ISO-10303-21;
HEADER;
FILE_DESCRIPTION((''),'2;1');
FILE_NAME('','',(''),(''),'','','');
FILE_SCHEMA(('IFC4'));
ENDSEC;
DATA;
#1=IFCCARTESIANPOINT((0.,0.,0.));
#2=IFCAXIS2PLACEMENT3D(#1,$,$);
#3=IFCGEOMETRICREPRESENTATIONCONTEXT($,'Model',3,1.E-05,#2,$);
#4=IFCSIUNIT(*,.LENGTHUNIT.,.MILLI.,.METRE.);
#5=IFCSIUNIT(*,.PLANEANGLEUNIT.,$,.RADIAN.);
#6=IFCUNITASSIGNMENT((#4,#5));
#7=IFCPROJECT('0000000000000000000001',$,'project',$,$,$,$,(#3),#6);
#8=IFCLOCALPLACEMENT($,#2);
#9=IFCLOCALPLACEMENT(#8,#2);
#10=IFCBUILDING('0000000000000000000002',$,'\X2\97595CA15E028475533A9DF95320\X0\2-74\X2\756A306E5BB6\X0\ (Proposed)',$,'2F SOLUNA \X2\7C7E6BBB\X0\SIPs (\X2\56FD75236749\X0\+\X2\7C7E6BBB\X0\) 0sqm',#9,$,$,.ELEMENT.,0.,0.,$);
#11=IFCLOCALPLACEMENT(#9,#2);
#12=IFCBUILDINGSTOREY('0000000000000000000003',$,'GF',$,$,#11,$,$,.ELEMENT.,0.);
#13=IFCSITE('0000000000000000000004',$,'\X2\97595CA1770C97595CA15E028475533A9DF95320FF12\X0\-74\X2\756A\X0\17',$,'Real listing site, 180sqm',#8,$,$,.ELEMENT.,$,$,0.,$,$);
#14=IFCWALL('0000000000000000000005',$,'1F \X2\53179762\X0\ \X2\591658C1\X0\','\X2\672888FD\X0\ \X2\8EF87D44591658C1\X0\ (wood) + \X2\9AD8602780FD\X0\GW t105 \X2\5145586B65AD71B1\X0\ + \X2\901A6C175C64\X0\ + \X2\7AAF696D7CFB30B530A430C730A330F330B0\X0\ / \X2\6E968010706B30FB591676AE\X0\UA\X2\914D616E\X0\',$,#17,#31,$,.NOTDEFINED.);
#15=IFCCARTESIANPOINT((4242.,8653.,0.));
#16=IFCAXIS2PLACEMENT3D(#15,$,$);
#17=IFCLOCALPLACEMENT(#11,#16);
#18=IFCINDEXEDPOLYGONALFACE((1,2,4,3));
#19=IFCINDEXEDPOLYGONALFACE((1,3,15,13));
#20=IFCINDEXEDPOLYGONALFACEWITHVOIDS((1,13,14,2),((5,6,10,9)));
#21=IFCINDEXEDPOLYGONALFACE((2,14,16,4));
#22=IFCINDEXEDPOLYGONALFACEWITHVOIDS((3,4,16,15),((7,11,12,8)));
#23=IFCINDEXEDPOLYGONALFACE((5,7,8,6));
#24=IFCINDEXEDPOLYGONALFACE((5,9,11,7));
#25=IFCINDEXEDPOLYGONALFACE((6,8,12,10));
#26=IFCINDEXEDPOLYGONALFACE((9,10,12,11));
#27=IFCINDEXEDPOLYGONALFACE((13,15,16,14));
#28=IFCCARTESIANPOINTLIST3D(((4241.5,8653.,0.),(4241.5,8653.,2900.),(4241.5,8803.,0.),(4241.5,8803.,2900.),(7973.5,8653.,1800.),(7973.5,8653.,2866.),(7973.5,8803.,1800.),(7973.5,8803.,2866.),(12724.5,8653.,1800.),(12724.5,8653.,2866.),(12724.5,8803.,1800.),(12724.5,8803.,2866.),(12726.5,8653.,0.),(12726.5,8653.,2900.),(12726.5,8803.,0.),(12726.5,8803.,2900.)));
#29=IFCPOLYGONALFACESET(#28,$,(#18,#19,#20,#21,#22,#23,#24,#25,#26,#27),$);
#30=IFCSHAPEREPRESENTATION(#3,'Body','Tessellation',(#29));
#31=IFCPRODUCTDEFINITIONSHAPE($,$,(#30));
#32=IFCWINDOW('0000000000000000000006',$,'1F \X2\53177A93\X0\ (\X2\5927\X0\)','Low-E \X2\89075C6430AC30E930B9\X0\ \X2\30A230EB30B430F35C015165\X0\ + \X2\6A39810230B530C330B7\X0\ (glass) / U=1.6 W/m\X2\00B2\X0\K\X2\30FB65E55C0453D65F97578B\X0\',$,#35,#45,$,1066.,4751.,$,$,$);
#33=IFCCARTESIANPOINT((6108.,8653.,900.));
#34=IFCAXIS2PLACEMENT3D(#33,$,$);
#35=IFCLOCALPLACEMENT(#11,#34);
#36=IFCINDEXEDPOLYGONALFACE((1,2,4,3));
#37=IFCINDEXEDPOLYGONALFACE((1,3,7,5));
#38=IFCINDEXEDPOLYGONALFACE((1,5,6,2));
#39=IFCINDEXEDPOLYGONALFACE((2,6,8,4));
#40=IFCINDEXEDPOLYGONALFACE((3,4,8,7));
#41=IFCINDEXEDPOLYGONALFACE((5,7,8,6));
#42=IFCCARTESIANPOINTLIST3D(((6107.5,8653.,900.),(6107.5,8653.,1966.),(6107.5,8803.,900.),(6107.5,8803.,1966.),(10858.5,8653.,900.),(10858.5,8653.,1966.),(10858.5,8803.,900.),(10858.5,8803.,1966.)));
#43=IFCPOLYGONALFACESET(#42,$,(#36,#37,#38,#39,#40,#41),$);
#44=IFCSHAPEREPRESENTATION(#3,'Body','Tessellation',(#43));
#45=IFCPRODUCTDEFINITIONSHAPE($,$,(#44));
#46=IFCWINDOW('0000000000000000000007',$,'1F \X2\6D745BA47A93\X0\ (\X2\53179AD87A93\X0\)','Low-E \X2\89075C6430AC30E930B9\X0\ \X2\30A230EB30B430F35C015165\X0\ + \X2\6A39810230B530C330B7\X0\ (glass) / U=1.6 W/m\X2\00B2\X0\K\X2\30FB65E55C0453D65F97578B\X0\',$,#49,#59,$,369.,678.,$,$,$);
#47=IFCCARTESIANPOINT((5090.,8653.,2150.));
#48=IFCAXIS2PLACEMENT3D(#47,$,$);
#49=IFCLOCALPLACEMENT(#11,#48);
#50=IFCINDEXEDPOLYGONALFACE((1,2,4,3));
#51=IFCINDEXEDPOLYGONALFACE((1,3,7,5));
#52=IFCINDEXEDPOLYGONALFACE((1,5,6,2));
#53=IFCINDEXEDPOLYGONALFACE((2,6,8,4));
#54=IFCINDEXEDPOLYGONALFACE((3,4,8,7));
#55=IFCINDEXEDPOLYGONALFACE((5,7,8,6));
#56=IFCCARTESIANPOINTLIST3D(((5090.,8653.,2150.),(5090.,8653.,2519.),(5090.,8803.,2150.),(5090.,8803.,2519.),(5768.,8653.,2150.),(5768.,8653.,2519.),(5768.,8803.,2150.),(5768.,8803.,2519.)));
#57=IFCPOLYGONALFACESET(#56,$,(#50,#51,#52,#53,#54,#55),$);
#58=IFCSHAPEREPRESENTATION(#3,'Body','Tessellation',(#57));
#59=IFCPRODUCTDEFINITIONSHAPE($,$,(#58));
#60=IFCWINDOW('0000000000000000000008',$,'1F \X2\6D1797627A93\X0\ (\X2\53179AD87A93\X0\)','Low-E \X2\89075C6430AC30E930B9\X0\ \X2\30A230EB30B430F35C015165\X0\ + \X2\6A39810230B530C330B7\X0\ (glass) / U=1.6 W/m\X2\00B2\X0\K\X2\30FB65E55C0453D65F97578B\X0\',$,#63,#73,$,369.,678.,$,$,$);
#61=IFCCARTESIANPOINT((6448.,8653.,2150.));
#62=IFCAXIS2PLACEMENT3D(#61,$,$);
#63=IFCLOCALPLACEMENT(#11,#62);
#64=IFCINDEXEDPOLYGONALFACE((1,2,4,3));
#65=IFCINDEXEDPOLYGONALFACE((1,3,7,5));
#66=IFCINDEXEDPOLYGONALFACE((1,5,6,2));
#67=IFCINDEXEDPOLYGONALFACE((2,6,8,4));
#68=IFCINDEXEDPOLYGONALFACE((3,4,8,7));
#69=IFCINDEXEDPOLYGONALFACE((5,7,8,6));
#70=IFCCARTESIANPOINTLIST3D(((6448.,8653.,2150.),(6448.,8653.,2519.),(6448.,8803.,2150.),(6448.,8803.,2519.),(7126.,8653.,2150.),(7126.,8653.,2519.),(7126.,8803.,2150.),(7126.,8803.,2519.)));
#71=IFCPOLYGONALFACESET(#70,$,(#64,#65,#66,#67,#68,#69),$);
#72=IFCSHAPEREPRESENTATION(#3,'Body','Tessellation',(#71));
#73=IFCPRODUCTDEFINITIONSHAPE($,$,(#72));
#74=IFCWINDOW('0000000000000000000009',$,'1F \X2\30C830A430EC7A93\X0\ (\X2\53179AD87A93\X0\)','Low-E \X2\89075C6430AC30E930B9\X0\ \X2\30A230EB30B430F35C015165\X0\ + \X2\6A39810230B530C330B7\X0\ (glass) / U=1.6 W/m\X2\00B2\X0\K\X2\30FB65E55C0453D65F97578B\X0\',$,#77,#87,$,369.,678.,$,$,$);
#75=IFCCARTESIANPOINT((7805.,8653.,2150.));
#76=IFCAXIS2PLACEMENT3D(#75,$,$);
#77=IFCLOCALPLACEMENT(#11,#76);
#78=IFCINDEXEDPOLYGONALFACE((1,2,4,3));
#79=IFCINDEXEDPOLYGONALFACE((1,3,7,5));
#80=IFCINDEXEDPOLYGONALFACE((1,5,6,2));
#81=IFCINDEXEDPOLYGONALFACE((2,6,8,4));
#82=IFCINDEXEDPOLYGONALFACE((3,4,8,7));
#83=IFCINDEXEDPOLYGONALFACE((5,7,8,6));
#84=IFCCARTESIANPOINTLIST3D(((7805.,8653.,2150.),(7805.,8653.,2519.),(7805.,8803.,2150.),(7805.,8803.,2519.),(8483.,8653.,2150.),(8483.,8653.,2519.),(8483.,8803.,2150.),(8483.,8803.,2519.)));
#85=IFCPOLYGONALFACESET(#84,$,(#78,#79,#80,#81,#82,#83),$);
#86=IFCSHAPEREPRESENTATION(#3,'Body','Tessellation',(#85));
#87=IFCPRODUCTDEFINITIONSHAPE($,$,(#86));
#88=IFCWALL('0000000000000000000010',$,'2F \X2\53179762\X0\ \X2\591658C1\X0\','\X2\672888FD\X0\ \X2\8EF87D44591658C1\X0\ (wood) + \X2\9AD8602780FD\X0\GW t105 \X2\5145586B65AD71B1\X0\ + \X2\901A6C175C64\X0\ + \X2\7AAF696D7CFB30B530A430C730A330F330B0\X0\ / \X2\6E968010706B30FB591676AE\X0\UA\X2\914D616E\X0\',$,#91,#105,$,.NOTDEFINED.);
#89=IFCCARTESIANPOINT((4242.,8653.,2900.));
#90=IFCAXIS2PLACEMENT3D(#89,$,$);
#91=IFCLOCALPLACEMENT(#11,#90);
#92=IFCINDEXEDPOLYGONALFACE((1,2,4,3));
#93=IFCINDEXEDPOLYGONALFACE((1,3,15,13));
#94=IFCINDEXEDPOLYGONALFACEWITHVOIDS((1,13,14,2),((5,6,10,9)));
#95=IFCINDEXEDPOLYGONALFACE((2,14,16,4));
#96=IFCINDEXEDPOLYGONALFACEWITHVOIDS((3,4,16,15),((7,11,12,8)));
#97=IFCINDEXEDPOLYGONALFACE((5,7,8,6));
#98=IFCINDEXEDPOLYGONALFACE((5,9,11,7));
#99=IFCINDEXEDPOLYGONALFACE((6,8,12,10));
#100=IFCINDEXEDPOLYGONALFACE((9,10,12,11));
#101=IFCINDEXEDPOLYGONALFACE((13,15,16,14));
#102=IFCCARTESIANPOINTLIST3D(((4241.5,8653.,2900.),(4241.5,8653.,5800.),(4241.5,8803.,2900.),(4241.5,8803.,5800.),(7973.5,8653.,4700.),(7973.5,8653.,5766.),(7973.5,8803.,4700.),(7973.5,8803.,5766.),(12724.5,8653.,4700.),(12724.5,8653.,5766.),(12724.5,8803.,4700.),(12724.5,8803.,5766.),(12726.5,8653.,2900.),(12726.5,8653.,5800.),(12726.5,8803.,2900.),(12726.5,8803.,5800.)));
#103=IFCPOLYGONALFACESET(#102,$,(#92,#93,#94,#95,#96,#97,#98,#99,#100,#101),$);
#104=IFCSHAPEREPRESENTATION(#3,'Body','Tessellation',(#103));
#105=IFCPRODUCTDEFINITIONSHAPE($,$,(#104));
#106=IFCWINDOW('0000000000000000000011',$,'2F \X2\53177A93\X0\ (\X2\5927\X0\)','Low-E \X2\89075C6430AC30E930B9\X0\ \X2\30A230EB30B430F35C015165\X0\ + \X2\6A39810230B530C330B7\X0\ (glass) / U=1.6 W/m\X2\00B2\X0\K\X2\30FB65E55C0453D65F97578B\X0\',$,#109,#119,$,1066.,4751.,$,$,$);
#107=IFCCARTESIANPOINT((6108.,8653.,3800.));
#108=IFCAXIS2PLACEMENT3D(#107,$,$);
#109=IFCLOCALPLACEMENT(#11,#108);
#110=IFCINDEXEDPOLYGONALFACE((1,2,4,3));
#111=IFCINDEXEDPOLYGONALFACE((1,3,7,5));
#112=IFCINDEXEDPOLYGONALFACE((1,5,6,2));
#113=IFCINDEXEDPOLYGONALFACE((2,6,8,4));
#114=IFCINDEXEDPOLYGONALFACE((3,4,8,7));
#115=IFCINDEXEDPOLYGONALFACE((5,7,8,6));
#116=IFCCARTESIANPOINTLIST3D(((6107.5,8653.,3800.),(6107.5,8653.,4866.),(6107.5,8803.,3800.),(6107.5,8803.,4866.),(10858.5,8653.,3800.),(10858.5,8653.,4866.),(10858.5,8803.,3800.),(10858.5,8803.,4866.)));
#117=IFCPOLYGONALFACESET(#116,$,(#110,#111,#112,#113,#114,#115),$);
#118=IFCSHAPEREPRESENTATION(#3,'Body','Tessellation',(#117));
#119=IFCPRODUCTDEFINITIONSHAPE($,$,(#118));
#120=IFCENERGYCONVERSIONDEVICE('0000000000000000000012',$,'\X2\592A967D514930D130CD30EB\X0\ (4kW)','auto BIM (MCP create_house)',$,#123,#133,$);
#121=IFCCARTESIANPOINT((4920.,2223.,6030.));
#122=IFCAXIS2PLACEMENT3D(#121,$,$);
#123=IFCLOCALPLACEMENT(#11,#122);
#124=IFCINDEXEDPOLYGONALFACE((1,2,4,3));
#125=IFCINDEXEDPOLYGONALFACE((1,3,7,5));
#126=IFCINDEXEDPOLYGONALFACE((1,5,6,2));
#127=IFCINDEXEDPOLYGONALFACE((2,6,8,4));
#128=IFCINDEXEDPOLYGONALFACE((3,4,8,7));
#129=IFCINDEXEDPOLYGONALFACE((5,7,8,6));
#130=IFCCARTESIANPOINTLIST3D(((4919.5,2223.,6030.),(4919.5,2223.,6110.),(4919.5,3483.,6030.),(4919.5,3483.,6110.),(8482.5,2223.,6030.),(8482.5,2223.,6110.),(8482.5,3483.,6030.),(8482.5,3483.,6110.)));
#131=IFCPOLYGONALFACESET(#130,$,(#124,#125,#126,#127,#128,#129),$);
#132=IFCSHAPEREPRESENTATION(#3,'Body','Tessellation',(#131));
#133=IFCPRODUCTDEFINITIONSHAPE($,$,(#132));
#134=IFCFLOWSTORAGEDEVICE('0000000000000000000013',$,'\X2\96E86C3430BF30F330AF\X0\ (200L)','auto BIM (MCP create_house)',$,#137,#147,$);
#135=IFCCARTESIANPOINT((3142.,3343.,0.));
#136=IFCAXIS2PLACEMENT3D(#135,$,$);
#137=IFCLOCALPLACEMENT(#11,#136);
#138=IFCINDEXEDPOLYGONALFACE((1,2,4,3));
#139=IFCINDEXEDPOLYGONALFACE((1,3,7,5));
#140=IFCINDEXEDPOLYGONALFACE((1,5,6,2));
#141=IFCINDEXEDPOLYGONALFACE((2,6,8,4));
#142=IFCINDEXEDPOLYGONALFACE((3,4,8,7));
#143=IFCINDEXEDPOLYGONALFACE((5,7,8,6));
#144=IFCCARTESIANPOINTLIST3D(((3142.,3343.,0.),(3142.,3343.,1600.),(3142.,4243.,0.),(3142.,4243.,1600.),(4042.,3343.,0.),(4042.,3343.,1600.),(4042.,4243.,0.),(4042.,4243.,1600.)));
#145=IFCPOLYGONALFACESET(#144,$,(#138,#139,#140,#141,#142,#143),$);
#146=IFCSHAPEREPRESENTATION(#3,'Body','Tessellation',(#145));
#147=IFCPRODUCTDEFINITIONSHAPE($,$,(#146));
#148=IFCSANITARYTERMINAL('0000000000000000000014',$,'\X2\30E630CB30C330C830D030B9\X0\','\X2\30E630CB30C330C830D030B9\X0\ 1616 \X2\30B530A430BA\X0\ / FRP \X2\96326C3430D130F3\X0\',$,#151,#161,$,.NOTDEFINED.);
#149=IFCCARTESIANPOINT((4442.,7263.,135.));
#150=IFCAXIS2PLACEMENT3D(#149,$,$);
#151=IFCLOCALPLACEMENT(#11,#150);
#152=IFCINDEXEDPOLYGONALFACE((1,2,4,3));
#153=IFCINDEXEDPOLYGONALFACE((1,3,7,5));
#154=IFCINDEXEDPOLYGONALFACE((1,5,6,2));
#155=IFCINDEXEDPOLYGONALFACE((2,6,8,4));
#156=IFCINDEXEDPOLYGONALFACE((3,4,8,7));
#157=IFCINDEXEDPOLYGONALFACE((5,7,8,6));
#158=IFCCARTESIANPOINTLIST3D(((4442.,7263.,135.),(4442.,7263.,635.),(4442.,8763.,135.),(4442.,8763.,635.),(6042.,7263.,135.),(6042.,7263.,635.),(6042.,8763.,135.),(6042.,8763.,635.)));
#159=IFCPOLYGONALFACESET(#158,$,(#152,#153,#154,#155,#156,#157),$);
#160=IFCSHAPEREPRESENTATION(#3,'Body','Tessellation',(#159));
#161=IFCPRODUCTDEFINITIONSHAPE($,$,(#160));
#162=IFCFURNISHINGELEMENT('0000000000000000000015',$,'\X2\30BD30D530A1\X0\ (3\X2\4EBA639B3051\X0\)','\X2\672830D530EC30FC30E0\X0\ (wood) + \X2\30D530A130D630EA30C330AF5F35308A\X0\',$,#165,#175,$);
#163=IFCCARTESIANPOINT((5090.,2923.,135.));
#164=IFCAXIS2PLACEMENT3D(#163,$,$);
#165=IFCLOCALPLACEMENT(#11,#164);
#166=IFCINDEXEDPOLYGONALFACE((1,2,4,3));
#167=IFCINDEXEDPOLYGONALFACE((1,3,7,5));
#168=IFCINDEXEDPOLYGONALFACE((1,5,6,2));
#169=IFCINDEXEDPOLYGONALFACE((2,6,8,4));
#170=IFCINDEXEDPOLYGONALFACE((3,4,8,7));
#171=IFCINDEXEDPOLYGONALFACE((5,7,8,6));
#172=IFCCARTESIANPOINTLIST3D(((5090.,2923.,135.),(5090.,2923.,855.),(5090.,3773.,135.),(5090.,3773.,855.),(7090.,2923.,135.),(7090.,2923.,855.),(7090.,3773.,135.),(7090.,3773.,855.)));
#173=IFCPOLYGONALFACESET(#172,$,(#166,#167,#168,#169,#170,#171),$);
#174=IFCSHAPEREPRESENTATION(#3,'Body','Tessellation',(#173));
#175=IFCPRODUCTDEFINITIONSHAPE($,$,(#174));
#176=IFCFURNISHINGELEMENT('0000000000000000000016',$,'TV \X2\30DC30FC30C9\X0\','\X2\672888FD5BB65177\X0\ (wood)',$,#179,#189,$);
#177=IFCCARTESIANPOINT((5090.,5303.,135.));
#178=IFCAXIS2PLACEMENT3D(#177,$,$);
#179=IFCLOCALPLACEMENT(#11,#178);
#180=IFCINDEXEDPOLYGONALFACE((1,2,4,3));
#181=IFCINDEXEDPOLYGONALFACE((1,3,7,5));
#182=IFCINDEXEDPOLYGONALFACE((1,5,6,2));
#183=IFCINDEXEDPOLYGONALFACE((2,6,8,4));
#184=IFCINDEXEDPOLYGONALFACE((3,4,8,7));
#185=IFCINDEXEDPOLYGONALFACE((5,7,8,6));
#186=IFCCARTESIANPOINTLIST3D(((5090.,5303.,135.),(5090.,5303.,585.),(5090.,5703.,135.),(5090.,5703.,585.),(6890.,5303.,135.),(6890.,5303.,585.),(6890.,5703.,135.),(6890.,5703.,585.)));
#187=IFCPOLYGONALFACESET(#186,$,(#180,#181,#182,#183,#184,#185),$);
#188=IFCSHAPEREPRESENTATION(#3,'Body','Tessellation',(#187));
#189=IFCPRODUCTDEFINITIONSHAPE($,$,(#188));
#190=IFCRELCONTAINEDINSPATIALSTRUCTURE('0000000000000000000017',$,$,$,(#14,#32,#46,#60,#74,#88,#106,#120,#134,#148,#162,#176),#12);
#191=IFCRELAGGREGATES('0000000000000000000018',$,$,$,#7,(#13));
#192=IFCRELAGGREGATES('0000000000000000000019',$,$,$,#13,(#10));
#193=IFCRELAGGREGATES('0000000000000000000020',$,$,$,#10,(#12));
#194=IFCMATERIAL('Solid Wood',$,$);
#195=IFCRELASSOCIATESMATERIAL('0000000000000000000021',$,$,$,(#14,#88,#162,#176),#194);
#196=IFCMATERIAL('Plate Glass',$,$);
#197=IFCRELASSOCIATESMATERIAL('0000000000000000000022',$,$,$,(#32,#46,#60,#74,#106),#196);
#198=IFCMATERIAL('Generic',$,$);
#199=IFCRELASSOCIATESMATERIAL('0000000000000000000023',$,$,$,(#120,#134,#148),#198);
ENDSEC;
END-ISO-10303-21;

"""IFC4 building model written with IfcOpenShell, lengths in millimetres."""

from ifc_helpers import new_model, si_unit, frame, frame_2d, origin, place, context, project, spatial, rectangle, extrude, material, element, fill, save


model = new_model("IFC4")

# Units and contexts
model_context = context("Model", 3, precision=1e-05, world=origin())
ifc_project = project(units=[si_unit("LENGTHUNIT", "METRE", prefix="MILLI"), si_unit("PLANEANGLEUNIT", "RADIAN")], contexts=[model_context])

# Site, building, storey
site_placement = place(None, origin())
site = spatial("IfcSite", under=ifc_project, at=site_placement, Name="静岡県静岡市葵区鷹匠２-74番17", ObjectType="Real listing site, 180sqm", CompositionType="ELEMENT", RefElevation=0.0)
building_placement = place(site_placement, origin())
building = spatial("IfcBuilding", under=site, at=building_placement, Name="静岡市葵区鷹匠2-74番の家 (Proposed)", ObjectType="2F SOLUNA 籾殻SIPs (国産杉+籾殻) 0sqm", CompositionType="ELEMENT", ElevationOfRefHeight=0.0, ElevationOfTerrain=0.0)
storey_placement = place(building_placement, origin())
storey = spatial("IfcBuildingStorey", under=building, at=storey_placement, Name="GF", CompositionType="ELEMENT", Elevation=0.0)

# Wall, openings, windows
ifc_material_1 = material(Name="Solid Wood")
wall_1_placement = place(storey_placement, frame((4242.0, 8653.0, 0.0)))
wall_1 = element("IfcWall", 1, at=wall_1_placement, inside=storey, material=ifc_material_1, Name="1F 北面 外壁", Description="木製 軸組外壁 (wood) + 高性能GW t105 充填断熱 + 通気層 + 窯業系サイディング / 準耐火・外皮UA配慮", PredefinedType="NOTDEFINED", context=model_context, shape_type="SweptSolid", body=[
    extrude(rectangle(XDim=8485.0, YDim=150.0, at=frame_2d((4242.0, 75.0))), frame((4242.0, 8653.0, 0.0)), (0.0, 0.0, 1.0), 2900.0),
])
opening_1_placement = place(storey_placement, frame((6108.0, 8653.0, 900.0)))
opening_1 = element("IfcOpeningElement", 2, at=opening_1_placement, cuts=wall_1, PredefinedType="NOTDEFINED", context=model_context, shape_type="SweptSolid", body=[
    extrude(rectangle(XDim=4751.0, YDim=150.0, at=frame_2d((2375.0, 75.0))), frame((6108.0, 8653.0, 900.0)), (0.0, 0.0, 1.0), 1066.0),
])
opening_2_placement = place(storey_placement, frame((5090.0, 8653.0, 2150.0)))
opening_2 = element("IfcOpeningElement", 3, at=opening_2_placement, cuts=wall_1, PredefinedType="NOTDEFINED", context=model_context, shape_type="SweptSolid", body=[
    extrude(rectangle(XDim=678.0, YDim=150.0, at=frame_2d((339.0, 75.0))), frame((5090.0, 8653.0, 2150.0)), (0.0, 0.0, 1.0), 369.0),
])
opening_3_placement = place(storey_placement, frame((6448.0, 8653.0, 2150.0)))
opening_3 = element("IfcOpeningElement", 4, at=opening_3_placement, cuts=wall_1, PredefinedType="NOTDEFINED", context=model_context, shape_type="SweptSolid", body=[
    extrude(rectangle(XDim=678.0, YDim=150.0, at=frame_2d((339.0, 75.0))), frame((6448.0, 8653.0, 2150.0)), (0.0, 0.0, 1.0), 369.0),
])
opening_4_placement = place(storey_placement, frame((7805.0, 8653.0, 2150.0)))
opening_4 = element("IfcOpeningElement", 5, at=opening_4_placement, cuts=wall_1, PredefinedType="NOTDEFINED", context=model_context, shape_type="SweptSolid", body=[
    extrude(rectangle(XDim=678.0, YDim=150.0, at=frame_2d((339.0, 75.0))), frame((7805.0, 8653.0, 2150.0)), (0.0, 0.0, 1.0), 369.0),
])
ifc_material_2 = material(Name="Plate Glass")
window_1_placement = place(storey_placement, frame((6108.0, 8653.0, 900.0)))
window_1 = element("IfcWindow", 6, at=window_1_placement, inside=storey, material=ifc_material_2, Name="1F 北窓 (大)", Description="Low-E 複層ガラス アルゴン封入 + 樹脂サッシ (glass) / U=1.6 W/m²K・日射取得型", OverallHeight=1066.0, OverallWidth=4751.0, context=model_context, shape_type="SweptSolid", body=[
    extrude(rectangle(XDim=4751.0, YDim=150.0, at=frame_2d((2375.0, 75.0))), frame((6108.0, 8653.0, 900.0)), (0.0, 0.0, 1.0), 1066.0),
])
fill(opening_1, window_1)
window_2_placement = place(storey_placement, frame((5090.0, 8653.0, 2150.0)))
window_2 = element("IfcWindow", 7, at=window_2_placement, inside=storey, material=ifc_material_2, Name="1F 浴室窓 (北高窓)", Description="Low-E 複層ガラス アルゴン封入 + 樹脂サッシ (glass) / U=1.6 W/m²K・日射取得型", OverallHeight=369.0, OverallWidth=678.0, context=model_context, shape_type="SweptSolid", body=[
    extrude(rectangle(XDim=678.0, YDim=150.0, at=frame_2d((339.0, 75.0))), frame((5090.0, 8653.0, 2150.0)), (0.0, 0.0, 1.0), 369.0),
])
fill(opening_2, window_2)
window_3_placement = place(storey_placement, frame((6448.0, 8653.0, 2150.0)))
window_3 = element("IfcWindow", 8, at=window_3_placement, inside=storey, material=ifc_material_2, Name="1F 洗面窓 (北高窓)", Description="Low-E 複層ガラス アルゴン封入 + 樹脂サッシ (glass) / U=1.6 W/m²K・日射取得型", OverallHeight=369.0, OverallWidth=678.0, context=model_context, shape_type="SweptSolid", body=[
    extrude(rectangle(XDim=678.0, YDim=150.0, at=frame_2d((339.0, 75.0))), frame((6448.0, 8653.0, 2150.0)), (0.0, 0.0, 1.0), 369.0),
])
fill(opening_3, window_3)
window_4_placement = place(storey_placement, frame((7805.0, 8653.0, 2150.0)))
window_4 = element("IfcWindow", 9, at=window_4_placement, inside=storey, material=ifc_material_2, Name="1F トイレ窓 (北高窓)", Description="Low-E 複層ガラス アルゴン封入 + 樹脂サッシ (glass) / U=1.6 W/m²K・日射取得型", OverallHeight=369.0, OverallWidth=678.0, context=model_context, shape_type="SweptSolid", body=[
    extrude(rectangle(XDim=678.0, YDim=150.0, at=frame_2d((339.0, 75.0))), frame((7805.0, 8653.0, 2150.0)), (0.0, 0.0, 1.0), 369.0),
])
fill(opening_4, window_4)

# Wall, opening, window
wall_2_placement = place(storey_placement, frame((4242.0, 8653.0, 2900.0)))
wall_2 = element("IfcWall", 10, at=wall_2_placement, inside=storey, material=ifc_material_1, Name="2F 北面 外壁", Description="木製 軸組外壁 (wood) + 高性能GW t105 充填断熱 + 通気層 + 窯業系サイディング / 準耐火・外皮UA配慮", PredefinedType="NOTDEFINED", context=model_context, shape_type="SweptSolid", body=[
    extrude(rectangle(XDim=8485.0, YDim=150.0, at=frame_2d((4242.0, 75.0))), frame((4242.0, 8653.0, 2900.0)), (0.0, 0.0, 1.0), 2900.0),
])
opening_5_placement = place(storey_placement, frame((6108.0, 8653.0, 3800.0)))
opening_5 = element("IfcOpeningElement", 11, at=opening_5_placement, cuts=wall_2, PredefinedType="NOTDEFINED", context=model_context, shape_type="SweptSolid", body=[
    extrude(rectangle(XDim=4751.0, YDim=150.0, at=frame_2d((2375.0, 75.0))), frame((6108.0, 8653.0, 3800.0)), (0.0, 0.0, 1.0), 1066.0),
])
window_5_placement = place(storey_placement, frame((6108.0, 8653.0, 3800.0)))
window_5 = element("IfcWindow", 12, at=window_5_placement, inside=storey, material=ifc_material_2, Name="2F 北窓 (大)", Description="Low-E 複層ガラス アルゴン封入 + 樹脂サッシ (glass) / U=1.6 W/m²K・日射取得型", OverallHeight=1066.0, OverallWidth=4751.0, context=model_context, shape_type="SweptSolid", body=[
    extrude(rectangle(XDim=4751.0, YDim=150.0, at=frame_2d((2375.0, 75.0))), frame((6108.0, 8653.0, 3800.0)), (0.0, 0.0, 1.0), 1066.0),
])
fill(opening_5, window_5)

# Energy conversion device
ifc_material_3 = material(Name="Generic")
energy_conversion_device_placement = place(storey_placement, frame((4920.0, 2223.0, 6030.0)))
element("IfcEnergyConversionDevice", 13, at=energy_conversion_device_placement, inside=storey, material=ifc_material_3, Name="太陽光パネル (4kW)", Description="auto BIM (MCP create_house)", context=model_context, shape_type="SweptSolid", body=[
    extrude(rectangle(XDim=3563.0, YDim=1260.0, at=frame_2d((1781.0, 630.0))), frame((4920.0, 2223.0, 6030.0)), (0.0, 0.0, 1.0), 80.0),
])

# Flow storage device
flow_storage_device_placement = place(storey_placement, frame((3142.0, 3343.0, 0.0)))
element("IfcFlowStorageDevice", 14, at=flow_storage_device_placement, inside=storey, material=ifc_material_3, Name="雨水タンク (200L)", Description="auto BIM (MCP create_house)", context=model_context, shape_type="SweptSolid", body=[
    extrude(rectangle(XDim=900.0, YDim=900.0, at=frame_2d((450.0, 450.0))), frame((3142.0, 3343.0, 0.0)), (0.0, 0.0, 1.0), 1600.0),
])

# Sanitary terminal
sanitary_terminal_placement = place(storey_placement, frame((4442.0, 7263.0, 135.0)))
element("IfcSanitaryTerminal", 15, at=sanitary_terminal_placement, inside=storey, material=ifc_material_3, Name="ユニットバス", Description="ユニットバス 1616 サイズ / FRP 防水パン", PredefinedType="NOTDEFINED", context=model_context, shape_type="SweptSolid", body=[
    extrude(rectangle(XDim=1600.0, YDim=1500.0, at=frame_2d((800.0, 750.0))), frame((4442.0, 7263.0, 135.0)), (0.0, 0.0, 1.0), 500.0),
])

# Furnishing elements
furnishing_1_placement = place(storey_placement, frame((5090.0, 2923.0, 135.0)))
element("IfcFurnishingElement", 16, at=furnishing_1_placement, inside=storey, material=ifc_material_1, Name="ソファ (3人掛け)", Description="木フレーム (wood) + ファブリック張り", context=model_context, shape_type="SweptSolid", body=[
    extrude(rectangle(XDim=2000.0, YDim=850.0, at=frame_2d((1000.0, 425.0))), frame((5090.0, 2923.0, 135.0)), (0.0, 0.0, 1.0), 720.0),
])
furnishing_2_placement = place(storey_placement, frame((5090.0, 5303.0, 135.0)))
element("IfcFurnishingElement", 17, at=furnishing_2_placement, inside=storey, material=ifc_material_1, Name="TV ボード", Description="木製家具 (wood)", context=model_context, shape_type="SweptSolid", body=[
    extrude(rectangle(XDim=1800.0, YDim=400.0, at=frame_2d((900.0, 200.0))), frame((5090.0, 5303.0, 135.0)), (0.0, 0.0, 1.0), 450.0),
])

save(model, "model.ifc")
